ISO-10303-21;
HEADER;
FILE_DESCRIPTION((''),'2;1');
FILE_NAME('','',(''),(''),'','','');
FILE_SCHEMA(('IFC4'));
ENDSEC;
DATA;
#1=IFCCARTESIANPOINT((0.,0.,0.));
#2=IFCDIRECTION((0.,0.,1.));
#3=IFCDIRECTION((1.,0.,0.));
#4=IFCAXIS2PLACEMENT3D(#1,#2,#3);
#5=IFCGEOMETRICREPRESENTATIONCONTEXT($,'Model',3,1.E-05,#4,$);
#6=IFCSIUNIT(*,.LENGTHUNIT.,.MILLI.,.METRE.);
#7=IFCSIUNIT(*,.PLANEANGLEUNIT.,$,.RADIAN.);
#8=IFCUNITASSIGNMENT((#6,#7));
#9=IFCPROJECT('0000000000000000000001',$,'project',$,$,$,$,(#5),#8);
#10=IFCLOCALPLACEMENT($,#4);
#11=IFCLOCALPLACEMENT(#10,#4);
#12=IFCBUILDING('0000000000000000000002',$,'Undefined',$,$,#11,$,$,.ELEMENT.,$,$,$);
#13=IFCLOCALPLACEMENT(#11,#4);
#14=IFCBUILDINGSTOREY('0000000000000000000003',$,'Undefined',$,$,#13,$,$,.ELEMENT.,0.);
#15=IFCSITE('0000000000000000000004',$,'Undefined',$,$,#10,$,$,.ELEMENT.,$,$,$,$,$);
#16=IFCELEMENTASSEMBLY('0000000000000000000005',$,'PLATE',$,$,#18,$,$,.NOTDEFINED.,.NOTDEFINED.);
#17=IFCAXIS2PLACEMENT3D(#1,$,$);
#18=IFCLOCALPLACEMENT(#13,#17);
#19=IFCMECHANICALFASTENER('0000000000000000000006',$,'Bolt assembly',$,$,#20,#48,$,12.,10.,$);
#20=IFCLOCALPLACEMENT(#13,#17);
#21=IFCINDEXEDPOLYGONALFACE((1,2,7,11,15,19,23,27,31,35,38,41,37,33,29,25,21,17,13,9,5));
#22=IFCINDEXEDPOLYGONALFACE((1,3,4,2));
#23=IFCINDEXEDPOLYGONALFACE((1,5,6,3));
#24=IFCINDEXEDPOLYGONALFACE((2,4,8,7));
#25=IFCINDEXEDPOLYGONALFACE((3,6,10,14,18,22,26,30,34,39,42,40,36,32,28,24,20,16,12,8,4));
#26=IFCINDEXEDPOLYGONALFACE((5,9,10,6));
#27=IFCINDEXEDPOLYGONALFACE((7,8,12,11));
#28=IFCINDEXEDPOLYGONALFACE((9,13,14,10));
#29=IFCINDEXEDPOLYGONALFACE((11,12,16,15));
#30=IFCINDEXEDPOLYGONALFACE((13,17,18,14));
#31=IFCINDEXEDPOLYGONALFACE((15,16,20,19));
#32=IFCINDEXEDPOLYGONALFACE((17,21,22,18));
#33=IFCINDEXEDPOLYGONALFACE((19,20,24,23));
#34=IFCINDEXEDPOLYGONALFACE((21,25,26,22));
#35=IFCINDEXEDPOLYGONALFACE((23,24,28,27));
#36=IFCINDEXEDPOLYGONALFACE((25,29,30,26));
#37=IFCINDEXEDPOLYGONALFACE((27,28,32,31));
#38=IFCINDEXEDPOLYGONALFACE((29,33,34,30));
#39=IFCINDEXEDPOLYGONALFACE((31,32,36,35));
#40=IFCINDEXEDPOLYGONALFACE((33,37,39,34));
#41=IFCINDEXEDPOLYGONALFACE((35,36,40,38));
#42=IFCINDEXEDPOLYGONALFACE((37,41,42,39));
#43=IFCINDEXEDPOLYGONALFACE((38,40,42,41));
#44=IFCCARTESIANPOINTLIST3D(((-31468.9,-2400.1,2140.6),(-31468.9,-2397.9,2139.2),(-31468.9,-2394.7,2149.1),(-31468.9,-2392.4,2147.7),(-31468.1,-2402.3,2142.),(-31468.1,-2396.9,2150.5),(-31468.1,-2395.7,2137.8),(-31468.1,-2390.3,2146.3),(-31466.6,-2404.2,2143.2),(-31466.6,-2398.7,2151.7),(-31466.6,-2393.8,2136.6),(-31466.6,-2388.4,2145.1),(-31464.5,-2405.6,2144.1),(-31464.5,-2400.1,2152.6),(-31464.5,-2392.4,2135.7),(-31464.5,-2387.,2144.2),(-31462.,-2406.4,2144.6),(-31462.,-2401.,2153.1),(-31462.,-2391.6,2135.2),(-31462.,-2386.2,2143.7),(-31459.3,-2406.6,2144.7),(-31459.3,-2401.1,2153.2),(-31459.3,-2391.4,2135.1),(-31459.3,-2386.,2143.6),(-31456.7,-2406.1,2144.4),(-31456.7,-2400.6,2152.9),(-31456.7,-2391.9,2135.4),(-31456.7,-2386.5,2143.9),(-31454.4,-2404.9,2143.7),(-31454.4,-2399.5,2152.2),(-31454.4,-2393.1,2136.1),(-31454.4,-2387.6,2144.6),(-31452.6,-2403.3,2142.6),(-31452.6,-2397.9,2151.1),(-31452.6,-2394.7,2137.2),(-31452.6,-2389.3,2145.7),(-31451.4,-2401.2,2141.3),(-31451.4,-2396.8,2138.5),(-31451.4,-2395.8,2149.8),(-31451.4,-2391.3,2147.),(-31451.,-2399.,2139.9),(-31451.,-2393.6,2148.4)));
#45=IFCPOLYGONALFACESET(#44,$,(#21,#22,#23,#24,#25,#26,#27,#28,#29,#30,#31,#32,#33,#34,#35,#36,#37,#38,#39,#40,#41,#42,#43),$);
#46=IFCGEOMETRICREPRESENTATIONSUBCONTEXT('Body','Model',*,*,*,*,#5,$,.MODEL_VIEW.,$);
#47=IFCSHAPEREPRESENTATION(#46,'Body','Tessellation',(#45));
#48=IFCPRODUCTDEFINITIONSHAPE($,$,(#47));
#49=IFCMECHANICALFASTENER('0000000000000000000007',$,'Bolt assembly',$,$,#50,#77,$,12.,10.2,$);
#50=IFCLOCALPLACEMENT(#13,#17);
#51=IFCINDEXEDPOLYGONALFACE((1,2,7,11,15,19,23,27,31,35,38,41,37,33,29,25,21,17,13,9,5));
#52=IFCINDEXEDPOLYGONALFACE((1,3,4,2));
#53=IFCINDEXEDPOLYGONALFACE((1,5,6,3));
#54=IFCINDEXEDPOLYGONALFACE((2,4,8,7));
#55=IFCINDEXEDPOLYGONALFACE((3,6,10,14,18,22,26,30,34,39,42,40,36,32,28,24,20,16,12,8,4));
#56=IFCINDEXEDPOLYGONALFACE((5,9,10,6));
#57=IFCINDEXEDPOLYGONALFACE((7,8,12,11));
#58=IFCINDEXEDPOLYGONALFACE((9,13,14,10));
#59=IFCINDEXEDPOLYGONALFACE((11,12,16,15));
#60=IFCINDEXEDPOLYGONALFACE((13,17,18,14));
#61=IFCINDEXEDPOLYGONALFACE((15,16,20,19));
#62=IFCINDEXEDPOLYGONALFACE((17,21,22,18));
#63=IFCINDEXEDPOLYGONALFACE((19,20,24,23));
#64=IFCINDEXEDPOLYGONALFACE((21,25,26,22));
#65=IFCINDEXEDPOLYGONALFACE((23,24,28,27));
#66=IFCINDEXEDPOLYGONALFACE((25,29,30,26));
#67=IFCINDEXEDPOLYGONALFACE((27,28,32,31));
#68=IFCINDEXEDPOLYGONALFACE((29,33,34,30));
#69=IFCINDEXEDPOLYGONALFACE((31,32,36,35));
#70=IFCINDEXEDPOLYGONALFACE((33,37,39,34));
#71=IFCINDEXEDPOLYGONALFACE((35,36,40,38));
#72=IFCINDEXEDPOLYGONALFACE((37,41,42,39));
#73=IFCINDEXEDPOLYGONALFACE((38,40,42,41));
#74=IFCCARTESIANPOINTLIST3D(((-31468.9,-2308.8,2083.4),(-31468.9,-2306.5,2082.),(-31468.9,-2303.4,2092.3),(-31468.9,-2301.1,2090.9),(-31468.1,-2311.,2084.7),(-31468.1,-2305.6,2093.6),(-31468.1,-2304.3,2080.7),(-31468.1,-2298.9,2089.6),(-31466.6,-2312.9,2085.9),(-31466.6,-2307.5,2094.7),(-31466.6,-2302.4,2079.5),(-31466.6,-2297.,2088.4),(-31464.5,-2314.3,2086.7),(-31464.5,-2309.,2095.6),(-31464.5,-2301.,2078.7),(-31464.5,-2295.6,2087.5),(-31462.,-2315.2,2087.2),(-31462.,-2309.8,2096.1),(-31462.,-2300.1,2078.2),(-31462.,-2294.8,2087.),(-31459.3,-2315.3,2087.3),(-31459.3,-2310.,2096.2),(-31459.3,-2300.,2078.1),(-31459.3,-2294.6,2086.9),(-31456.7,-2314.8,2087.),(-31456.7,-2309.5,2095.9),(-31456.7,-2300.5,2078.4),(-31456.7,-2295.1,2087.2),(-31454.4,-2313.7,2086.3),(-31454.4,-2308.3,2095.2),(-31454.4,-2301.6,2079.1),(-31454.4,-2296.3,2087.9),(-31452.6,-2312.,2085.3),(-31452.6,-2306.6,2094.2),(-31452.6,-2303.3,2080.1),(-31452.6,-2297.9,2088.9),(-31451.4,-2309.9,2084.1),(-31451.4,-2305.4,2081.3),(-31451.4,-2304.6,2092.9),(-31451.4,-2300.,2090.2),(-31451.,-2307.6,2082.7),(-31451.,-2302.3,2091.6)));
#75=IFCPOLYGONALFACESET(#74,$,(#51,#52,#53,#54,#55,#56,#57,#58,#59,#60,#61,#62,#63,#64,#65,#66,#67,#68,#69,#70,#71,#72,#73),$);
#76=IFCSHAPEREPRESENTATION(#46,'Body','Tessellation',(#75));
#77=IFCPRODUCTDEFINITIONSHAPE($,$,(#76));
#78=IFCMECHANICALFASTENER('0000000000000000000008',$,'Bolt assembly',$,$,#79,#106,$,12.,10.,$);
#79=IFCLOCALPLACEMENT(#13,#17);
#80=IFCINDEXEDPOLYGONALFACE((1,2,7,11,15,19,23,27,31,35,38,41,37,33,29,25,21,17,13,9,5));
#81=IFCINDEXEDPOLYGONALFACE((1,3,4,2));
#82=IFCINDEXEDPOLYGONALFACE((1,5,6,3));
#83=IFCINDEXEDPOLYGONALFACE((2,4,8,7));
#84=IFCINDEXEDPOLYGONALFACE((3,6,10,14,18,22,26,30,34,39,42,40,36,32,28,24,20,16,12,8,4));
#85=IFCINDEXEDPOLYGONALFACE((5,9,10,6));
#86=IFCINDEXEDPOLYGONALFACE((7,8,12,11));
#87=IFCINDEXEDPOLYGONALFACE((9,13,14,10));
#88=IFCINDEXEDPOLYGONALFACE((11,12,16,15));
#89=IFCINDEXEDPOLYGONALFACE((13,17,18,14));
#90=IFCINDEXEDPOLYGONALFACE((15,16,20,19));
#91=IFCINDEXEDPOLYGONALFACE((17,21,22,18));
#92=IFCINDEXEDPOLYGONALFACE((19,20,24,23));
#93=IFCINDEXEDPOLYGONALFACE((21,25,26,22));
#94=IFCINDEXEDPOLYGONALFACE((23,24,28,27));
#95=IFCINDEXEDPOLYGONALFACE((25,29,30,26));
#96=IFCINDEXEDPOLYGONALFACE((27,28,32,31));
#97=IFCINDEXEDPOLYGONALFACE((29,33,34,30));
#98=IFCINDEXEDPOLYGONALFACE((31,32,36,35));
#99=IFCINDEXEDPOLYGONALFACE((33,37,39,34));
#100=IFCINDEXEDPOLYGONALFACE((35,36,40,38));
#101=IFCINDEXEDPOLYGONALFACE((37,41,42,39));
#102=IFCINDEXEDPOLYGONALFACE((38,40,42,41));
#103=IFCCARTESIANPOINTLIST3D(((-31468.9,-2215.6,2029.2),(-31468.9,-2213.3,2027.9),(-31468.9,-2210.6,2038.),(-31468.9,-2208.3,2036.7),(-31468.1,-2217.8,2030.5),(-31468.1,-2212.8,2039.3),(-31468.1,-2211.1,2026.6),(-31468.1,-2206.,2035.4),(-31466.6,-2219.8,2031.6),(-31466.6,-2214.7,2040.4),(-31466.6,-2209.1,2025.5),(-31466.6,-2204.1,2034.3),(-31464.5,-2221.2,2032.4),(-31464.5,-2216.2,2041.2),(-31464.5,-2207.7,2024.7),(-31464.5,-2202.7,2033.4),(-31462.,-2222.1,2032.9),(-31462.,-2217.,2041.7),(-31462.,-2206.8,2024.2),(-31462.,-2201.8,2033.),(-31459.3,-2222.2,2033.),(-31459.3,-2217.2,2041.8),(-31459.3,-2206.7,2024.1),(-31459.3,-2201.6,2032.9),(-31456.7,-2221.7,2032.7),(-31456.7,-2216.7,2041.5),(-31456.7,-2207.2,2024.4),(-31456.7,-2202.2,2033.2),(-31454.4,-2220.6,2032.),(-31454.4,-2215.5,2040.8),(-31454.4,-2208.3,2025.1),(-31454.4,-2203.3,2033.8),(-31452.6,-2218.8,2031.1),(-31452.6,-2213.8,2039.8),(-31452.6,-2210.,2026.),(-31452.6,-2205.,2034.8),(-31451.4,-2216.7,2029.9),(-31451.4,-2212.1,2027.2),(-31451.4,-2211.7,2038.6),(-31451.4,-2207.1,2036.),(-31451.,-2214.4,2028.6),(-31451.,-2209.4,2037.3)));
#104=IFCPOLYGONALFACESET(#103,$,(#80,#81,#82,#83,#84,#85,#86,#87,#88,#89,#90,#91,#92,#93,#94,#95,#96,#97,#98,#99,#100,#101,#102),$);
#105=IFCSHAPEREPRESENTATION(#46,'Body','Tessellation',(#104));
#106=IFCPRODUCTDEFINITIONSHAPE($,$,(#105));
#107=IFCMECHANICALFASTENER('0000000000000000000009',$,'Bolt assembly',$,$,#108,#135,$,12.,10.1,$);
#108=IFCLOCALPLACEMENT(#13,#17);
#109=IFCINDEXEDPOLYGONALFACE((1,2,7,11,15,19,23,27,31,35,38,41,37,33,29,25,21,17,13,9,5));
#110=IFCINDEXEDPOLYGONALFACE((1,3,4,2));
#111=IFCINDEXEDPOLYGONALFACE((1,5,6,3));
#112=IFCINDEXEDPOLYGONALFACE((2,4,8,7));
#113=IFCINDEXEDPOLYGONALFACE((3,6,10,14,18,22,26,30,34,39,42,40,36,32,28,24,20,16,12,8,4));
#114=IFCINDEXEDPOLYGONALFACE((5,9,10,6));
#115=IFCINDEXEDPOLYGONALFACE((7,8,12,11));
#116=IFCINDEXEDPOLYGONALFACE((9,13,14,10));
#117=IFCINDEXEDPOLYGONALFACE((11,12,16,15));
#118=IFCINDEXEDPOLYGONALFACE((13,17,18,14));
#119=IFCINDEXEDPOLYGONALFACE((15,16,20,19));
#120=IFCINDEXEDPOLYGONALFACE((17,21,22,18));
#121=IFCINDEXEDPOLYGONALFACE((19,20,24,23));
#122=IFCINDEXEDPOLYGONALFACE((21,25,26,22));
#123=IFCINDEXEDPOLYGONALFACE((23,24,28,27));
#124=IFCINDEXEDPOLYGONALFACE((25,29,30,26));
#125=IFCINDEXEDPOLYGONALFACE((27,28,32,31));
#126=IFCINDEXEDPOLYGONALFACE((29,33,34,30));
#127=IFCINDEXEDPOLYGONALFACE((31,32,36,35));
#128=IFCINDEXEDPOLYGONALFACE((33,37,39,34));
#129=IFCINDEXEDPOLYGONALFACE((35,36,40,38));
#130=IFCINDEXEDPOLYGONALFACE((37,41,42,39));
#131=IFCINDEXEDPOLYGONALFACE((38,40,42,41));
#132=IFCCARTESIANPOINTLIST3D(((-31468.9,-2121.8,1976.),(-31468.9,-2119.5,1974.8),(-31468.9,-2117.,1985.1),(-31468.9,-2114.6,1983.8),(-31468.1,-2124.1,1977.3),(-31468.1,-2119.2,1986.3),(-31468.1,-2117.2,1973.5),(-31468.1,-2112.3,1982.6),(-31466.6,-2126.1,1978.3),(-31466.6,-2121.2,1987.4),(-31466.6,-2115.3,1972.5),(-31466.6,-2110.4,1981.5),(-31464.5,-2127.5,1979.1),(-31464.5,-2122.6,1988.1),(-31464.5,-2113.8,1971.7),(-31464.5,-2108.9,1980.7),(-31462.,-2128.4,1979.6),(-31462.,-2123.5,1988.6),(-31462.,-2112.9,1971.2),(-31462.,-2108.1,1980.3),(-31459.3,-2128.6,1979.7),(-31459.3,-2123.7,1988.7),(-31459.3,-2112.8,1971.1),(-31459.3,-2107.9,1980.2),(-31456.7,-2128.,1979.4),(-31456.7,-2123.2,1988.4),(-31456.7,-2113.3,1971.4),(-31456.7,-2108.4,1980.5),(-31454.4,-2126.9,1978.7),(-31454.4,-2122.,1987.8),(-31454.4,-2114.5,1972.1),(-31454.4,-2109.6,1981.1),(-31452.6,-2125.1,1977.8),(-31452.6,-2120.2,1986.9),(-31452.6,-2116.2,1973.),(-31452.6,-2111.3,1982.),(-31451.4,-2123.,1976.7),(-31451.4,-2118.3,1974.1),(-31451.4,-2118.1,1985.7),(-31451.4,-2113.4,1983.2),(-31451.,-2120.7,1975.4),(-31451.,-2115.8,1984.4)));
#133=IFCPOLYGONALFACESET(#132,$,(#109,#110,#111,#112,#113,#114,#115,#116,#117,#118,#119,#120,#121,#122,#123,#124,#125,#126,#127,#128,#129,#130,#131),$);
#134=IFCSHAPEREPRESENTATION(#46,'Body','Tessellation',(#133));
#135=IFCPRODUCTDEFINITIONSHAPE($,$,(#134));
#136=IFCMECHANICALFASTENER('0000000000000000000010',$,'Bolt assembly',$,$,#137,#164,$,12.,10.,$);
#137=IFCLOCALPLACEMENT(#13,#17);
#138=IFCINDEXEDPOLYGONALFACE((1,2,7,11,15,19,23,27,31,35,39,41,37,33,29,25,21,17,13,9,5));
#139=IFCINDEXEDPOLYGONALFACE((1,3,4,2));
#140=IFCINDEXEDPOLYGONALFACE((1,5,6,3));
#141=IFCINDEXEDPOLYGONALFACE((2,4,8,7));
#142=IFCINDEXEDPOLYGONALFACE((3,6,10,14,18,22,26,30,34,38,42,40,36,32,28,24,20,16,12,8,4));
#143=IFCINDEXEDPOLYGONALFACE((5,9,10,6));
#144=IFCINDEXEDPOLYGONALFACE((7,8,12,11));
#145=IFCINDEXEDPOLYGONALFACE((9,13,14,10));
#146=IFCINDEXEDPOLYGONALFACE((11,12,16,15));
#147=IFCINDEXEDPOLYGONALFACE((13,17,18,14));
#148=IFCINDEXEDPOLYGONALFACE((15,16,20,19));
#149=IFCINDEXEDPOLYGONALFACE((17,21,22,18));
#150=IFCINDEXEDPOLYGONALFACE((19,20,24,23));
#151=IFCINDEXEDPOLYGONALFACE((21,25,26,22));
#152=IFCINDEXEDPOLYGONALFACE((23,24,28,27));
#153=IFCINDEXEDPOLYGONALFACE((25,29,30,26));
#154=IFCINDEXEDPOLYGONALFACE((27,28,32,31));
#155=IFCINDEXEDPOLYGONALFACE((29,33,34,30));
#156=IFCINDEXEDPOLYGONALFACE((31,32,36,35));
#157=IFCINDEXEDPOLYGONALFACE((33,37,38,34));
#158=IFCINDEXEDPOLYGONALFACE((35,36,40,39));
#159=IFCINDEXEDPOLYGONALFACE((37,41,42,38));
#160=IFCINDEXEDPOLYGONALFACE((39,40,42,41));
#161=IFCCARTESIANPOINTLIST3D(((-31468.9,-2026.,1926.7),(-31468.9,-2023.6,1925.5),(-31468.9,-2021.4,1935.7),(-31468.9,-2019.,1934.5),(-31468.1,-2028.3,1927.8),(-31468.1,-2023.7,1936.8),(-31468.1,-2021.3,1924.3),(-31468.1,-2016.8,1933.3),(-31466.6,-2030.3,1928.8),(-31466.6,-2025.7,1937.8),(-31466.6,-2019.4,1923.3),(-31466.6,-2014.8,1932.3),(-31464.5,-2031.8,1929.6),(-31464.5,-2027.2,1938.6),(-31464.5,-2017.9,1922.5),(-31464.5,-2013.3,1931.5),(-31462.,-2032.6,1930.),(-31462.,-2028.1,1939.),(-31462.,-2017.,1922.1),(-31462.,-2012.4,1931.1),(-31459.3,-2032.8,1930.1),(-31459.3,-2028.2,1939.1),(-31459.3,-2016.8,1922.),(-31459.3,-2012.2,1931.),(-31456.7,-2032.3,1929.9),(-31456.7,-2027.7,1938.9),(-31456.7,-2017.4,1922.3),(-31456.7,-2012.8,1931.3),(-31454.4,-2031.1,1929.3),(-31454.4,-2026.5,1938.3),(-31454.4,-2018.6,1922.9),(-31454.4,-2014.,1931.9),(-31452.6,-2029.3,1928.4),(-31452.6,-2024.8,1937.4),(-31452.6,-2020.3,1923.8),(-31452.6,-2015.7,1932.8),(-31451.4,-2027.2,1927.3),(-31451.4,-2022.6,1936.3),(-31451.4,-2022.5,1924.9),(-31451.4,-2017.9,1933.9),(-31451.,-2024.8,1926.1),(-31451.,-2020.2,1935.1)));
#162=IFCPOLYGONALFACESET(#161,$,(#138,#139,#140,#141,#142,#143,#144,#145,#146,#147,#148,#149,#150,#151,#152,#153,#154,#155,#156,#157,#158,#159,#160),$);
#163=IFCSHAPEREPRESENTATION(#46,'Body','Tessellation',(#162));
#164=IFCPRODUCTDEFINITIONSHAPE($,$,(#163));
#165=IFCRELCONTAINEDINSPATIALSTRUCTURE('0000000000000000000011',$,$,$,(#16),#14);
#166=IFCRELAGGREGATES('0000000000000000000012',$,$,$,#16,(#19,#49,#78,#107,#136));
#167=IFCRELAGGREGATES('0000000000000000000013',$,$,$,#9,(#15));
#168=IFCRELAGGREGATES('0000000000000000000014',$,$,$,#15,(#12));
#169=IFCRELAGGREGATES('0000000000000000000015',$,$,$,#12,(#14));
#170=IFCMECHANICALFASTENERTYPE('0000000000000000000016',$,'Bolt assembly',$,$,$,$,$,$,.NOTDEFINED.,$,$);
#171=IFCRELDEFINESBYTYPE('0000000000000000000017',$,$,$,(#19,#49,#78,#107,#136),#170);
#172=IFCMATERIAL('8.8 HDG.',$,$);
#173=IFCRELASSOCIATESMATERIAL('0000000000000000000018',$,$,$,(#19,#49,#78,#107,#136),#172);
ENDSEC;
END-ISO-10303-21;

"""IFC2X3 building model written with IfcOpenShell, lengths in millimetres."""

from ifc_helpers import new_model, si_unit, frame, origin_with_axes, origin_2d_with_axis, place, context, subcontext, project, spatial, circle, extrude, source, transform, mapped, material, type_object, element, aggregate, save


model = new_model("IFC2X3")

# Units and contexts
model_context = context("Model", 3, precision=1e-05, world=origin_with_axes())
body_context = subcontext(model_context, "Body", "Model", "MODEL_VIEW")
ifc_project = project(units=[si_unit("LENGTHUNIT", "METRE", prefix="MILLI"), si_unit("PLANEANGLEUNIT", "RADIAN")], contexts=[model_context])

# Site, building, storey
site_placement = place(None, origin_with_axes())
site = spatial("IfcSite", under=ifc_project, at=site_placement, Name="Undefined", CompositionType="ELEMENT")
building_placement = place(site_placement, origin_with_axes())
building = spatial("IfcBuilding", under=site, at=building_placement, Name="Undefined", CompositionType="ELEMENT")
storey_placement = place(building_placement, origin_with_axes())
storey = spatial("IfcBuildingStorey", under=building, at=storey_placement, Name="Undefined", CompositionType="ELEMENT", Elevation=0.0)

# Element assembly, mechanical fasteners
assembly_placement = place(storey_placement, origin_with_axes())
assembly = element("IfcElementAssembly", 1, at=assembly_placement, inside=storey, Name="PLATE", AssemblyPlace="NOTDEFINED", PredefinedType="NOTDEFINED")
ifc_material_1 = material(Name="8.8 HDG.")
mechanical_fastener_type = type_object("IfcMechanicalFastenerType", Name="Bolt assembly")
shared_shape_1 = source(origin_with_axes(), body_context, "Body", "SweptSolid", [
    extrude(circle(Radius=9.0, at=origin_2d_with_axis()), frame((0.0, 0.7, 0.0), z_axis=(0.0, 1.0, 0.0), x_axis=(1.0, 0.0, 0.0)), (0.0, 0.0, 1.0), 10.1),
])
mechanical_fastener_1_placement = place(assembly_placement, frame((-31460.0, -2399.4, 2139.3), z_axis=(0.000001, -0.843031, 0.537866), x_axis=(1.0, 0.000001, -0.000001)))
mechanical_fastener_1 = element("IfcMechanicalFastener", 2, at=mechanical_fastener_1_placement, type_object=mechanical_fastener_type, material=ifc_material_1, Name="Bolt assembly", NominalDiameter=12.0, NominalLength=10.0, context=body_context, shape_type="MappedRepresentation", body=[
    mapped(shared_shape_1, transform((0.0, 0.0, 0.0))),
])
shared_shape_2 = source(origin_with_axes(), body_context, "Body", "SweptSolid", [
    extrude(circle(Radius=9.0, at=origin_2d_with_axis()), frame((0.0, 0.4, 0.0), z_axis=(0.0, 1.0, 0.0), x_axis=(1.0, 0.0, 0.0)), (0.0, 0.0, 1.0), 10.4),
])
mechanical_fastener_2_placement = place(assembly_placement, frame((-31460.0, -2307.8, 2082.4), z_axis=(0.000001, -0.855781, 0.517338), x_axis=(1.0, 0.000001, -0.000001)))
mechanical_fastener_2 = element("IfcMechanicalFastener", 3, at=mechanical_fastener_2_placement, type_object=mechanical_fastener_type, material=ifc_material_1, Name="Bolt assembly", NominalDiameter=12.0, NominalLength=10.2, context=body_context, shape_type="MappedRepresentation", body=[
    mapped(shared_shape_2, transform((0.0, 0.0, 0.0))),
])
shared_shape_3 = source(origin_with_axes(), body_context, "Body", "SweptSolid", [
    extrude(circle(Radius=9.0, at=origin_2d_with_axis()), frame((0.0, 0.9, 0.0), z_axis=(0.0, 1.0, 0.0), x_axis=(1.0, 0.0, 0.0)), (0.0, 0.0, 1.0), 10.1),
])
mechanical_fastener_3_placement = place(assembly_placement, frame((-31460.0, -2214.9, 2027.8), z_axis=(0.000001, -0.868032, 0.496508), x_axis=(1.0, 0.000001, -0.000001)))
mechanical_fastener_3 = element("IfcMechanicalFastener", 4, at=mechanical_fastener_3_placement, type_object=mechanical_fastener_type, material=ifc_material_1, Name="Bolt assembly", NominalDiameter=12.0, NominalLength=10.0, context=body_context, shape_type="MappedRepresentation", body=[
    mapped(shared_shape_3, transform((0.0, 0.0, 0.0))),
])
shared_shape_4 = source(origin_with_axes(), body_context, "Body", "SweptSolid", [
    extrude(circle(Radius=9.0, at=origin_2d_with_axis()), frame((0.0, 0.0, 0.0), z_axis=(0.0, 1.0, 0.0), x_axis=(1.0, 0.0, 0.0)), (0.0, 0.0, 1.0), 10.3),
])
mechanical_fastener_4_placement = place(assembly_placement, frame((-31460.0, -2120.7, 1975.4), z_axis=(0.000001, -0.879776, 0.475388), x_axis=(1.0, 0.000001, -0.000001)))
mechanical_fastener_4 = element("IfcMechanicalFastener", 5, at=mechanical_fastener_4_placement, type_object=mechanical_fastener_type, material=ifc_material_1, Name="Bolt assembly", NominalDiameter=12.0, NominalLength=10.1, context=body_context, shape_type="MappedRepresentation", body=[
    mapped(shared_shape_4, transform((0.0, 0.0, 0.0))),
])
shared_shape_5 = source(origin_with_axes(), body_context, "Body", "SweptSolid", [
    extrude(circle(Radius=9.0, at=origin_2d_with_axis()), frame((0.0, 0.9, 0.0), z_axis=(0.0, 1.0, 0.0), x_axis=(1.0, 0.0, 0.0)), (0.0, 0.0, 1.0), 10.1),
])
mechanical_fastener_5_placement = place(assembly_placement, frame((-31460.0, -2025.2, 1925.3), z_axis=(0.000001, -0.891006, 0.453991), x_axis=(1.0, 0.000001, -0.000001)))
mechanical_fastener_5 = element("IfcMechanicalFastener", 6, at=mechanical_fastener_5_placement, type_object=mechanical_fastener_type, material=ifc_material_1, Name="Bolt assembly", NominalDiameter=12.0, NominalLength=10.0, context=body_context, shape_type="MappedRepresentation", body=[
    mapped(shared_shape_5, transform((0.0, 0.0, 0.0))),
])
aggregate(assembly, [mechanical_fastener_1, mechanical_fastener_2, mechanical_fastener_3, mechanical_fastener_4, mechanical_fastener_5])

save(model, "model.ifc")
